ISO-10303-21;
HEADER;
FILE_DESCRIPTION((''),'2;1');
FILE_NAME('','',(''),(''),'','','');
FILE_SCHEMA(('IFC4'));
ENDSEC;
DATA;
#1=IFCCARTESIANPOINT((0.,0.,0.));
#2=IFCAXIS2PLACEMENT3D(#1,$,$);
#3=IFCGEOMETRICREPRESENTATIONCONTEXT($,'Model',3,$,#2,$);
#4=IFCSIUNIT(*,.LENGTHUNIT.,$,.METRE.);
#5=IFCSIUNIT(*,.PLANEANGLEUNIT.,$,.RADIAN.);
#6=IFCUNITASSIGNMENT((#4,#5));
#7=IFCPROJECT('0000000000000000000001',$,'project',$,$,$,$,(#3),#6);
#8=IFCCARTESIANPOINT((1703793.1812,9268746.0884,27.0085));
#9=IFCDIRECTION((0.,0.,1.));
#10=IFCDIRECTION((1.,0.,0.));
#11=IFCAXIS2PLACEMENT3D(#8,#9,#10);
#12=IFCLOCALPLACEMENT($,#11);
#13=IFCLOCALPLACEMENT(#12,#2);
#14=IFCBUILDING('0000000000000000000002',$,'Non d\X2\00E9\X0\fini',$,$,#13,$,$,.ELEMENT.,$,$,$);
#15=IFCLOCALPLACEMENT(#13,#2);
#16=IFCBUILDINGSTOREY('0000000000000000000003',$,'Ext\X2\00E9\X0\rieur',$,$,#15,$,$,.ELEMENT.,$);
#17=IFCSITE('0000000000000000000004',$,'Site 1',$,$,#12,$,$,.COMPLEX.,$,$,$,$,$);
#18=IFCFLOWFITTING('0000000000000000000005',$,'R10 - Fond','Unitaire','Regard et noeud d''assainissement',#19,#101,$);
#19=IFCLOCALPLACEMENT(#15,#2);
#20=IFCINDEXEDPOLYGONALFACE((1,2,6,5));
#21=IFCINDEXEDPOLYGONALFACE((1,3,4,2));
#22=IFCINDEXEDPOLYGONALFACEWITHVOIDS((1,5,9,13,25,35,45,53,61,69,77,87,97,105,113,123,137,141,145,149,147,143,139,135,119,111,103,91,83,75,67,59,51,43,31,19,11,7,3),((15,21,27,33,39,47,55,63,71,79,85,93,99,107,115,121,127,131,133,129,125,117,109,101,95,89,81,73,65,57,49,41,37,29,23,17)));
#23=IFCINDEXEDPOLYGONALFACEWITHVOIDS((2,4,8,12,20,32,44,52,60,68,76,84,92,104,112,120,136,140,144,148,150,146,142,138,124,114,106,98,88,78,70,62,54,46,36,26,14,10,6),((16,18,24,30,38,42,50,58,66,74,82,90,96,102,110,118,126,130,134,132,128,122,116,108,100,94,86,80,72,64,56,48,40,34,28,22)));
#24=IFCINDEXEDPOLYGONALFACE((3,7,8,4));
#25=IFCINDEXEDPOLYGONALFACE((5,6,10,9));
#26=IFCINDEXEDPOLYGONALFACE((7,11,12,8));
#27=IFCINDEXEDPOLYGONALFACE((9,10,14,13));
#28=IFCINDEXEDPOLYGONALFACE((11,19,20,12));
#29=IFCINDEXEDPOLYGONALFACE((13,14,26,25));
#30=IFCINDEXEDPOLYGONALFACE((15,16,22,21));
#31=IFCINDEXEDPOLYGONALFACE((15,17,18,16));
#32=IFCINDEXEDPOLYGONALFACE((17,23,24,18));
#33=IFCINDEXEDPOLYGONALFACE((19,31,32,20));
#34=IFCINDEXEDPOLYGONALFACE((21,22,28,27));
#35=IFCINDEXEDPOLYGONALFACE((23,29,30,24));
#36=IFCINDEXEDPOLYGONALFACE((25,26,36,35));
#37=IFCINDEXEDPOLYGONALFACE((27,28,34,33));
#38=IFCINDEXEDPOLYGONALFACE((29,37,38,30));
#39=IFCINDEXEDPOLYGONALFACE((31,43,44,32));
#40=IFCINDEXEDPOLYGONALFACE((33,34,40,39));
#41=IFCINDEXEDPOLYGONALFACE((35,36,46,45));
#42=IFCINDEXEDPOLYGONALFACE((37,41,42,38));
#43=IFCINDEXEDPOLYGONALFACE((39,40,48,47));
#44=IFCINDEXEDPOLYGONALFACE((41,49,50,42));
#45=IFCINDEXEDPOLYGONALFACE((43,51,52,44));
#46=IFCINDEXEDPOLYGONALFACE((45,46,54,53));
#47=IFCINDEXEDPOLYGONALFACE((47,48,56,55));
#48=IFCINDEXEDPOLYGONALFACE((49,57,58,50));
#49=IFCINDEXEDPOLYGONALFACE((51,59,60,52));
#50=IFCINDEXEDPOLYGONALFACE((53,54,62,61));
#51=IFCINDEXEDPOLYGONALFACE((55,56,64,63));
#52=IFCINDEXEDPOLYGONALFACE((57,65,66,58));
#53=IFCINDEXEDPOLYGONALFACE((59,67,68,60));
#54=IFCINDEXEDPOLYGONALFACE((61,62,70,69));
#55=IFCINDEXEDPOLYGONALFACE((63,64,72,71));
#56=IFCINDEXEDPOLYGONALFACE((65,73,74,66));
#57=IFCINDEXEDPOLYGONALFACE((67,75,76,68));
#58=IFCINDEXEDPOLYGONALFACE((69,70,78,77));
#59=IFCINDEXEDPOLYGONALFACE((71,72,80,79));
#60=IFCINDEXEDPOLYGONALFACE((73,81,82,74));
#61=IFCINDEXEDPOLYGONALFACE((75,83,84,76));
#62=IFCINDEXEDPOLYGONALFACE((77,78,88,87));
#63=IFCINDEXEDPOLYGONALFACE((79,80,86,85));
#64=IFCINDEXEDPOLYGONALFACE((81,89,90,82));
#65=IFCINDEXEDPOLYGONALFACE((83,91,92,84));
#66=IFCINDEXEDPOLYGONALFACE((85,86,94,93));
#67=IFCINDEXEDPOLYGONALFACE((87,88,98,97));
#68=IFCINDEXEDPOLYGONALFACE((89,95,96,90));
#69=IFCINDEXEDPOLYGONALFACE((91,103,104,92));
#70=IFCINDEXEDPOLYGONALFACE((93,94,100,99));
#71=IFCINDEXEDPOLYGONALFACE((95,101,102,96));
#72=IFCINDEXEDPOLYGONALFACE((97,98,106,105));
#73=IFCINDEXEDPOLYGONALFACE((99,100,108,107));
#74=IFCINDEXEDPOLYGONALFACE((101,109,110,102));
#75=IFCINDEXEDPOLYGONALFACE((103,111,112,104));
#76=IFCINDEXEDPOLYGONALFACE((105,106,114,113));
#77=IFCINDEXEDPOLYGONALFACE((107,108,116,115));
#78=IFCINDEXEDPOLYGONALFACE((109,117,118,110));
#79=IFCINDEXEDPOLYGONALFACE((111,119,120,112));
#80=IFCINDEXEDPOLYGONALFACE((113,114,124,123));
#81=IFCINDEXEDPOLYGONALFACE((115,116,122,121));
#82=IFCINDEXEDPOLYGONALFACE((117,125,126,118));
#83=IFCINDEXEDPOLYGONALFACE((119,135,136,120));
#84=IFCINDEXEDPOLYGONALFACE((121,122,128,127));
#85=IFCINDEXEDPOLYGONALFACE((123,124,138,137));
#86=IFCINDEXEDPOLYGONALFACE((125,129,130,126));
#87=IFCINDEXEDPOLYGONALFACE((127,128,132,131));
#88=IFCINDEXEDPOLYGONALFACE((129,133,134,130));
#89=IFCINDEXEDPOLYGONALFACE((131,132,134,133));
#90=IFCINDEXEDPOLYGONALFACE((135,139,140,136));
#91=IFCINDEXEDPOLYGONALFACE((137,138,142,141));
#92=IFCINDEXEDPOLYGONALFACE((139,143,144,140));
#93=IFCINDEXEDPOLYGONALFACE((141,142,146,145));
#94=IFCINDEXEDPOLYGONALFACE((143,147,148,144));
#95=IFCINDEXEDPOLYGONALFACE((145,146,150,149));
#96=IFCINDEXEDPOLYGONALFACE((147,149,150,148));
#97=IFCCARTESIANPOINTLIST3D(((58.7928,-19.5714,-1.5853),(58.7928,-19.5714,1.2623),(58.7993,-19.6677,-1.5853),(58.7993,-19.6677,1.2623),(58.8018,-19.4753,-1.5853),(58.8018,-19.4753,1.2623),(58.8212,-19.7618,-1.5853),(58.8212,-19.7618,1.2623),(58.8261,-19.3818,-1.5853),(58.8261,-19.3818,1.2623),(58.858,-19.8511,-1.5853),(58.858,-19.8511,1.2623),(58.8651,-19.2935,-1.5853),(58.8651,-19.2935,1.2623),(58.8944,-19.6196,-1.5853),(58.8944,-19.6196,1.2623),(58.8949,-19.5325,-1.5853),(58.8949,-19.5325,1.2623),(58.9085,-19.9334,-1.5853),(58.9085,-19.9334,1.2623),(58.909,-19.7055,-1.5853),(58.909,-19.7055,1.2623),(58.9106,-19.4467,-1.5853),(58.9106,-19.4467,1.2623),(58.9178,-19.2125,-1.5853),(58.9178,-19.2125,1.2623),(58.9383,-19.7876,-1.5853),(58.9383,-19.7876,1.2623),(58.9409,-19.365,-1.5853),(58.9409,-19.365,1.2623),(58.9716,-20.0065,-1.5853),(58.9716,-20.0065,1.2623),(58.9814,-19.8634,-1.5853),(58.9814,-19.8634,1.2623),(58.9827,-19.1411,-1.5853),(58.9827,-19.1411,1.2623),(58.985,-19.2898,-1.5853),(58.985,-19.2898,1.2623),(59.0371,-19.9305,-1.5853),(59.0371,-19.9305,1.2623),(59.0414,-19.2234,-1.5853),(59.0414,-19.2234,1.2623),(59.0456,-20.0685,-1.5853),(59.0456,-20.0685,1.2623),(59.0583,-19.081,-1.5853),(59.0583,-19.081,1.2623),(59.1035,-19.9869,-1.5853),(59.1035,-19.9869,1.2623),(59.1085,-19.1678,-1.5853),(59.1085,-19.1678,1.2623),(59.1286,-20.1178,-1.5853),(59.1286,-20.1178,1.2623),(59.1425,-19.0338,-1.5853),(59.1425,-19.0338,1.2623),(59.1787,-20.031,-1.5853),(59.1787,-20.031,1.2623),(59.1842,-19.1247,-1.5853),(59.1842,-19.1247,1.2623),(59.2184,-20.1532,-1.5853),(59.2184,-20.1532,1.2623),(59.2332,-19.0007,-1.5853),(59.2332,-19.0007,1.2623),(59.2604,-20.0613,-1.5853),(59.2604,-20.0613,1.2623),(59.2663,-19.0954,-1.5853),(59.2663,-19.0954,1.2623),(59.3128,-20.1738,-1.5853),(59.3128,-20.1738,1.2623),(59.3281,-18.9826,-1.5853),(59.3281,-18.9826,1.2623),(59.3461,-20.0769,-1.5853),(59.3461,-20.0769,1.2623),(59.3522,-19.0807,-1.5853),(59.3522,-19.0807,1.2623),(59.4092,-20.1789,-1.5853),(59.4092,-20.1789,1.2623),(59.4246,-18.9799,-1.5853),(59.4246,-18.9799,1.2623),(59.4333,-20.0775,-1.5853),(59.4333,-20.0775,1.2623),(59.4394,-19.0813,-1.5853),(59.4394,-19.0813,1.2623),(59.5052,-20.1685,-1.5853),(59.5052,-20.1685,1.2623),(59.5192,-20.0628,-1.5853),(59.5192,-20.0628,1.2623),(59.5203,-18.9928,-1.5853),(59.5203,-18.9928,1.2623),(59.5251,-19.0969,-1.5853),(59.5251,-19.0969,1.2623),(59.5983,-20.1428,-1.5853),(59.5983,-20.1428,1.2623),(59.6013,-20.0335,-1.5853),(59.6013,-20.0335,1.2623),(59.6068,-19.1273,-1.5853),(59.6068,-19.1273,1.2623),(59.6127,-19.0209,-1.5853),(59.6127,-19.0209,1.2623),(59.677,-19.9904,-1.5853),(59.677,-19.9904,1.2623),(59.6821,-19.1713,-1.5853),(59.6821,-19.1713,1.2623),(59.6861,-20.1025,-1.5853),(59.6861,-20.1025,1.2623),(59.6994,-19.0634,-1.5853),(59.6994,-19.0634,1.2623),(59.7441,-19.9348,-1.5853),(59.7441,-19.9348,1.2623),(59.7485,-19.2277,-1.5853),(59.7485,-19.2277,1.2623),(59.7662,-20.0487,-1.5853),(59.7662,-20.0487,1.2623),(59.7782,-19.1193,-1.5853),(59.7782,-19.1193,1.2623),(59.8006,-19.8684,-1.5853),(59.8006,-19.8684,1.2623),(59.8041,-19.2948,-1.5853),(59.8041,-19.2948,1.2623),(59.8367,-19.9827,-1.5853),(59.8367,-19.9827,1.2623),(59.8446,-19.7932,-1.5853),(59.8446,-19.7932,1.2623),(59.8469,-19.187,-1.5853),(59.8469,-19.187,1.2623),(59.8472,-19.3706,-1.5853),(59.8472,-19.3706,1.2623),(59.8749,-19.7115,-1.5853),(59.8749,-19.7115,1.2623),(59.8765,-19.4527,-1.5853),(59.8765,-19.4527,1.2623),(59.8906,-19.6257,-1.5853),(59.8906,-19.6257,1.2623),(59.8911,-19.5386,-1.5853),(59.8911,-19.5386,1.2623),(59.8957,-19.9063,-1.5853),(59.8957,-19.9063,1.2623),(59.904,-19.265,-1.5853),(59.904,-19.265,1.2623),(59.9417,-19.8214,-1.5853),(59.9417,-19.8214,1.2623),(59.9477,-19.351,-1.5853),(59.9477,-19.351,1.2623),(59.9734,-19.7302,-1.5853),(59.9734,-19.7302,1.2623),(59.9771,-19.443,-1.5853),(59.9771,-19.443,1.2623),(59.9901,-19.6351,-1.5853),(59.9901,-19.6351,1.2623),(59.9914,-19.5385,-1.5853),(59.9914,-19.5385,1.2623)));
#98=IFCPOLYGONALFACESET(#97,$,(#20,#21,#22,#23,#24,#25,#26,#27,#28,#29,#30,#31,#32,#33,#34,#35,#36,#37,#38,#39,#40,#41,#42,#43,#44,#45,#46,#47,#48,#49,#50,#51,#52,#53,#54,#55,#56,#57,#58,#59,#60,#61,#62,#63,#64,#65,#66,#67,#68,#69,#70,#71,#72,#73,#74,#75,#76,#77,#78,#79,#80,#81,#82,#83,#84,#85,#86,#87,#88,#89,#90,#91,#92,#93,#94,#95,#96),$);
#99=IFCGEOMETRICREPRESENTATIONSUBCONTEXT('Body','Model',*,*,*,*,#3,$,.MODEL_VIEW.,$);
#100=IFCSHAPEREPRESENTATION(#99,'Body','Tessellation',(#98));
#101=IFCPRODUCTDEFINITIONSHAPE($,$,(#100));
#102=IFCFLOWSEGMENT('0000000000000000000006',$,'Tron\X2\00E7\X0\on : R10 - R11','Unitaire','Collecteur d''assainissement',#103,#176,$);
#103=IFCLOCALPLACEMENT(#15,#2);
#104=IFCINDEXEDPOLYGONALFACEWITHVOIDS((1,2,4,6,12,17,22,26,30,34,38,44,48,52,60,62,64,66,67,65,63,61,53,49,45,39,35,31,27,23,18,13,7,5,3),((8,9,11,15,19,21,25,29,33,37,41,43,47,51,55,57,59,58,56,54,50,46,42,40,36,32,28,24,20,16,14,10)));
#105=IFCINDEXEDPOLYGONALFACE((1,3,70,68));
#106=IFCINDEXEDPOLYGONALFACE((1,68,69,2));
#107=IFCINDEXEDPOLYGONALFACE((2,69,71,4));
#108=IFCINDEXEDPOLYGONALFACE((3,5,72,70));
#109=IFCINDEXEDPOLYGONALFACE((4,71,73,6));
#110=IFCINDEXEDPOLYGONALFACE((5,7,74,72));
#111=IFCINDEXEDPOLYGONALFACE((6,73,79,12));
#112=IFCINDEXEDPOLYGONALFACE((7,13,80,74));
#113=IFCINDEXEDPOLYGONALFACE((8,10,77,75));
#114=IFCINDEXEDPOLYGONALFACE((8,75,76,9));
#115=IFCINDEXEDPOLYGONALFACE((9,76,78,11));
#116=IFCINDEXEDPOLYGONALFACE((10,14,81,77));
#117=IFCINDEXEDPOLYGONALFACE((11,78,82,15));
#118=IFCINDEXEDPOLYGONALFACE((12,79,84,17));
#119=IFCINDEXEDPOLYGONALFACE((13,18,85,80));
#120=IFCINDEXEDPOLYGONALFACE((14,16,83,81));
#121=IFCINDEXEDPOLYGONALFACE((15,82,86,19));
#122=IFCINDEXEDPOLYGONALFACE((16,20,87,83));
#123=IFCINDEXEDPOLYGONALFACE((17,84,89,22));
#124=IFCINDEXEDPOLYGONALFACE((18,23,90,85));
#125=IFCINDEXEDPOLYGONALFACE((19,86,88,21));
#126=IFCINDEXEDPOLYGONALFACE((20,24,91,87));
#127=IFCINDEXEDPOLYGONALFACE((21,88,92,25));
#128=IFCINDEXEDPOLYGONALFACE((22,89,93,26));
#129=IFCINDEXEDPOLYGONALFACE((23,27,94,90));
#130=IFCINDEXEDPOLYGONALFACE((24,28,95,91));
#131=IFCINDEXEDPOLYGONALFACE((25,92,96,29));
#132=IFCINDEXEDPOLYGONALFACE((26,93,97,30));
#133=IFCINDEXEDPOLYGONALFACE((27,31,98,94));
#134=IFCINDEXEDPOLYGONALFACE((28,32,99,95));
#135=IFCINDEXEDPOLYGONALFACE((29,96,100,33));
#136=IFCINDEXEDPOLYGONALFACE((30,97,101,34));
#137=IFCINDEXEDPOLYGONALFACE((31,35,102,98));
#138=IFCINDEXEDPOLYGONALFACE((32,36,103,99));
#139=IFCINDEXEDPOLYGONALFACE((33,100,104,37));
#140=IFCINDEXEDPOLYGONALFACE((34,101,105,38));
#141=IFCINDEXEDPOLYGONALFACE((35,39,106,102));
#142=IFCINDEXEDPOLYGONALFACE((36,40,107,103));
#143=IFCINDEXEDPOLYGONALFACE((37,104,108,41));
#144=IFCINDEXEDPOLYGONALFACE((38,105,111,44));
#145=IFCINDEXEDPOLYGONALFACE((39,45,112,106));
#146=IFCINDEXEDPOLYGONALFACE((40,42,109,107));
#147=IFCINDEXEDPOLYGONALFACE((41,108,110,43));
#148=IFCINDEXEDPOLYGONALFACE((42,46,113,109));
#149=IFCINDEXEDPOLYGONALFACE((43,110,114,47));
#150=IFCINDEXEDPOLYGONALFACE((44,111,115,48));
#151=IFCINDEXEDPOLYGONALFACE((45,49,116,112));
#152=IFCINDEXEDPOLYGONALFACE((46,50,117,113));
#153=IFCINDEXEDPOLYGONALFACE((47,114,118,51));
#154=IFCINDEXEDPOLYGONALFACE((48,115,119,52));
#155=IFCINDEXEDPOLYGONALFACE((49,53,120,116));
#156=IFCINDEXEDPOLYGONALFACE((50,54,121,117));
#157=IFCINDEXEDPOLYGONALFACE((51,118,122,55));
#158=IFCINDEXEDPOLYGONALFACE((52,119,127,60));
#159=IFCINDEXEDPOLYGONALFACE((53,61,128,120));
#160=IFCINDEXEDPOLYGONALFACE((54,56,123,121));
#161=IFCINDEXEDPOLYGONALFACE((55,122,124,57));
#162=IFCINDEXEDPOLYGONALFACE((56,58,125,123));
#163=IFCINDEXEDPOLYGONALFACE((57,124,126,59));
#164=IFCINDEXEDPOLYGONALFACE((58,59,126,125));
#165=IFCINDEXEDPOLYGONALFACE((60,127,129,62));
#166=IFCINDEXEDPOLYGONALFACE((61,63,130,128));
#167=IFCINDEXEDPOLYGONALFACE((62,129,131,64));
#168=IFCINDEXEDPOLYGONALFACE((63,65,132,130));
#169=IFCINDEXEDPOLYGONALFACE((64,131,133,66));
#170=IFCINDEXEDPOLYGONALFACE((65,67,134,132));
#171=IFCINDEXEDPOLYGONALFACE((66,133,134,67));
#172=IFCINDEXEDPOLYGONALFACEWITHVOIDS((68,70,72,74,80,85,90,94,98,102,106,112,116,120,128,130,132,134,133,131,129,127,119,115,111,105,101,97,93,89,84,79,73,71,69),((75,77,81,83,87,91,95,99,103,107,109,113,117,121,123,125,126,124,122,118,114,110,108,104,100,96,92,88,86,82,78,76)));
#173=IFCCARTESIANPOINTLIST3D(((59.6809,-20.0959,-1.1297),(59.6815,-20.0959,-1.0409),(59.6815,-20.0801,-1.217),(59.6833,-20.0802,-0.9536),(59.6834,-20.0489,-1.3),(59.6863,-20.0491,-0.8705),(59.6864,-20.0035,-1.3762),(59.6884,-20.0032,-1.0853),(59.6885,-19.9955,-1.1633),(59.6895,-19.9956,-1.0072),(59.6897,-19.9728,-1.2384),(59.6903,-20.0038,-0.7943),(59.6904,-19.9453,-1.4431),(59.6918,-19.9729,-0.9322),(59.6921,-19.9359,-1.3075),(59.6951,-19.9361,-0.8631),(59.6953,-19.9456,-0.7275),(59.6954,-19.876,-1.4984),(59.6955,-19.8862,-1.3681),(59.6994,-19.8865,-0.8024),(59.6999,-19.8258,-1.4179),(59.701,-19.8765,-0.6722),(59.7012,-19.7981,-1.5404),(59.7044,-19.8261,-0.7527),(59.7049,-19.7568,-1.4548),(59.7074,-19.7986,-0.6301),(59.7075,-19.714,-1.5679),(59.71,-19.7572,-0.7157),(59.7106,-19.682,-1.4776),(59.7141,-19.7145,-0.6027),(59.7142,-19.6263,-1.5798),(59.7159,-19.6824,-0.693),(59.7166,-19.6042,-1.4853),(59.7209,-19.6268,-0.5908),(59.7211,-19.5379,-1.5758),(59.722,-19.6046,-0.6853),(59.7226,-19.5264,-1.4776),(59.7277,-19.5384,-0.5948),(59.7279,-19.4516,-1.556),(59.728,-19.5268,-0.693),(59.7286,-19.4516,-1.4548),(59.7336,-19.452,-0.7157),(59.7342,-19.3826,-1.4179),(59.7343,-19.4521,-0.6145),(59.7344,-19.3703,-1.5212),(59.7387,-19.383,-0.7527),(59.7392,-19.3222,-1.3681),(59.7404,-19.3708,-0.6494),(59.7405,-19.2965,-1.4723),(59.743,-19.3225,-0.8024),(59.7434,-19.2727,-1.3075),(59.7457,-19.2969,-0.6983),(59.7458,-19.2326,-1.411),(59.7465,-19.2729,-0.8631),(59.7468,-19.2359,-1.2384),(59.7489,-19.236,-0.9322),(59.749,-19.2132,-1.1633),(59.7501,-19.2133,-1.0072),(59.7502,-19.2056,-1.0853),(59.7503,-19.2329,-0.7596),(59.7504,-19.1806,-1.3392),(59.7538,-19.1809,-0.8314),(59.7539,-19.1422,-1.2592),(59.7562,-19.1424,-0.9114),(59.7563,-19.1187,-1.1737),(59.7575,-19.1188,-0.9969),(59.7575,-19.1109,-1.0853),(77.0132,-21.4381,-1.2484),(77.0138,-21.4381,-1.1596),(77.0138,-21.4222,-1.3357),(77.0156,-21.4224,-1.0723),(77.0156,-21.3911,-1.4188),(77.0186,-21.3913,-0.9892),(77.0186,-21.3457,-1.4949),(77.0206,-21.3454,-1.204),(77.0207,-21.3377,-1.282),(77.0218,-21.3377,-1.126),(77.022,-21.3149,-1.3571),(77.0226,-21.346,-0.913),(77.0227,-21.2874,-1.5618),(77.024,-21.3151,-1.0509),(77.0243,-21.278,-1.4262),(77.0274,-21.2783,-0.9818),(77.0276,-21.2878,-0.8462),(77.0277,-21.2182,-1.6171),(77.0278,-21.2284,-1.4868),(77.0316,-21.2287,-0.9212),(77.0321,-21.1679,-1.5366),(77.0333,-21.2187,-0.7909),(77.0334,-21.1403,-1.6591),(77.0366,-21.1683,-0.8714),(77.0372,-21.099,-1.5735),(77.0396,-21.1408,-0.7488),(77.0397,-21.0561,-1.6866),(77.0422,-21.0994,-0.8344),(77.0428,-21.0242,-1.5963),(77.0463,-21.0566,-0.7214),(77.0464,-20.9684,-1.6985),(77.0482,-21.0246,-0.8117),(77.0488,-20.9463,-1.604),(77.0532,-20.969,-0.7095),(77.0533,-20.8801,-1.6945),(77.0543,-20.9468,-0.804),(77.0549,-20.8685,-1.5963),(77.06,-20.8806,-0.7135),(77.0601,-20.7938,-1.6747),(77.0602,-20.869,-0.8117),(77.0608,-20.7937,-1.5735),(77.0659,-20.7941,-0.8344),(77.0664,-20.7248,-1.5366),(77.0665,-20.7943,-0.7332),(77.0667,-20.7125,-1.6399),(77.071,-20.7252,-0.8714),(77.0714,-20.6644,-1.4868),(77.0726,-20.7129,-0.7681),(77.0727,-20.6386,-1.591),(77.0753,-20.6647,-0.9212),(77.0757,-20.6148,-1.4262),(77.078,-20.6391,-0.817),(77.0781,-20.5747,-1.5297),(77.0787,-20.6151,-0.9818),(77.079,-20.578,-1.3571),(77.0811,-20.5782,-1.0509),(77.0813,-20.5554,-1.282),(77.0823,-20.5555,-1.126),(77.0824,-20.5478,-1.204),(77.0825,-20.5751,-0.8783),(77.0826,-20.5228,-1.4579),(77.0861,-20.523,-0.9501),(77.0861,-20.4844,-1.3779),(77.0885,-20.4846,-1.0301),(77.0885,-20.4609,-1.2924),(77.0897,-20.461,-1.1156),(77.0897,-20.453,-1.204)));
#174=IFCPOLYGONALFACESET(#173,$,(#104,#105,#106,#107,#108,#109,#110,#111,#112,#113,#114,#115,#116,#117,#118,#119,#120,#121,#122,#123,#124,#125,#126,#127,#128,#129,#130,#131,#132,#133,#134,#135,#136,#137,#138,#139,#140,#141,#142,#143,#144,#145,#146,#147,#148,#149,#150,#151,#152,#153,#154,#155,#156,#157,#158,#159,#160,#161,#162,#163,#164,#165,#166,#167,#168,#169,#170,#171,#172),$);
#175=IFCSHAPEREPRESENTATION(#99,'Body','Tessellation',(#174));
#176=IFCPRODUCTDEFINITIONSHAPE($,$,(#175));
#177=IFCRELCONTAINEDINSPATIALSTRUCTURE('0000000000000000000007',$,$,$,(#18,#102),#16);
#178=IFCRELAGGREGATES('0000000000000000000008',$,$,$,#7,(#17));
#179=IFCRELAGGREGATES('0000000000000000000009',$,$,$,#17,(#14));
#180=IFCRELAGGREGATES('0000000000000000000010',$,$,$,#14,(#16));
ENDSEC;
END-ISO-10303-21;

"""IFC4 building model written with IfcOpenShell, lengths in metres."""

from ifc_helpers import new_model, si_unit, frame, origin, origin_2d, place, context, subcontext, project, spatial, hollow_circle, extrude, element, save


model = new_model("IFC4")

# Units and contexts
model_context = context("Model", 3, world=origin())
body_context = subcontext(model_context, "Body", "Model", "MODEL_VIEW")
ifc_project = project(units=[si_unit("LENGTHUNIT", "METRE"), si_unit("PLANEANGLEUNIT", "RADIAN")], contexts=[model_context])

# Site, building, storey
site_placement = place(None, frame((1703793.1812, 9268746.0884, 27.0085), z_axis=(0.0, 0.0, 1.0), x_axis=(1.0, 0.0, 0.0)))
site = spatial("IfcSite", under=ifc_project, at=site_placement, Name="Site 1", CompositionType="COMPLEX")
building_placement = place(site_placement, origin())
building = spatial("IfcBuilding", under=site, at=building_placement, Name="Non défini", CompositionType="ELEMENT")
storey_placement = place(building_placement, origin())
storey = spatial("IfcBuildingStorey", under=building, at=storey_placement, Name="Extérieur", CompositionType="ELEMENT")

# Flow fitting
flow_fitting_1_placement = place(storey_placement, origin())
element("IfcFlowFitting", 1, at=flow_fitting_1_placement, inside=storey, Name="R10 - Fond", Description="Unitaire", ObjectType="Regard et noeud d'assainissement", context=body_context, shape_type="SweptSolid", body=[
    extrude(hollow_circle(Radius=0.6, WallThickness=0.1, at=origin_2d()), frame((59.3928, -19.5791, -1.5853), z_axis=(0.0, 0.0, 1.0), x_axis=(0.995642, -0.093261, 0.0)), (0.0, 0.0, 1.0), 2.8476),
])

# Flow segment
flow_segment_1_placement = place(storey_placement, origin())
element("IfcFlowSegment", 2, at=flow_segment_1_placement, inside=storey, Name="Tronçon : R10 - R11", Description="Unitaire", ObjectType="Collecteur d'assainissement", context=body_context, shape_type="SweptSolid", body=[
    extrude(hollow_circle(Radius=0.495, WallThickness=0.095, at=origin_2d()), frame((59.7193, -19.6044, -1.0853), z_axis=(0.996992, -0.077205, -0.006828), x_axis=(0.077207, 0.997015, 0.0)), (0.0, 0.0, 1.0), 17.3845),
])

save(model, "model.ifc")
